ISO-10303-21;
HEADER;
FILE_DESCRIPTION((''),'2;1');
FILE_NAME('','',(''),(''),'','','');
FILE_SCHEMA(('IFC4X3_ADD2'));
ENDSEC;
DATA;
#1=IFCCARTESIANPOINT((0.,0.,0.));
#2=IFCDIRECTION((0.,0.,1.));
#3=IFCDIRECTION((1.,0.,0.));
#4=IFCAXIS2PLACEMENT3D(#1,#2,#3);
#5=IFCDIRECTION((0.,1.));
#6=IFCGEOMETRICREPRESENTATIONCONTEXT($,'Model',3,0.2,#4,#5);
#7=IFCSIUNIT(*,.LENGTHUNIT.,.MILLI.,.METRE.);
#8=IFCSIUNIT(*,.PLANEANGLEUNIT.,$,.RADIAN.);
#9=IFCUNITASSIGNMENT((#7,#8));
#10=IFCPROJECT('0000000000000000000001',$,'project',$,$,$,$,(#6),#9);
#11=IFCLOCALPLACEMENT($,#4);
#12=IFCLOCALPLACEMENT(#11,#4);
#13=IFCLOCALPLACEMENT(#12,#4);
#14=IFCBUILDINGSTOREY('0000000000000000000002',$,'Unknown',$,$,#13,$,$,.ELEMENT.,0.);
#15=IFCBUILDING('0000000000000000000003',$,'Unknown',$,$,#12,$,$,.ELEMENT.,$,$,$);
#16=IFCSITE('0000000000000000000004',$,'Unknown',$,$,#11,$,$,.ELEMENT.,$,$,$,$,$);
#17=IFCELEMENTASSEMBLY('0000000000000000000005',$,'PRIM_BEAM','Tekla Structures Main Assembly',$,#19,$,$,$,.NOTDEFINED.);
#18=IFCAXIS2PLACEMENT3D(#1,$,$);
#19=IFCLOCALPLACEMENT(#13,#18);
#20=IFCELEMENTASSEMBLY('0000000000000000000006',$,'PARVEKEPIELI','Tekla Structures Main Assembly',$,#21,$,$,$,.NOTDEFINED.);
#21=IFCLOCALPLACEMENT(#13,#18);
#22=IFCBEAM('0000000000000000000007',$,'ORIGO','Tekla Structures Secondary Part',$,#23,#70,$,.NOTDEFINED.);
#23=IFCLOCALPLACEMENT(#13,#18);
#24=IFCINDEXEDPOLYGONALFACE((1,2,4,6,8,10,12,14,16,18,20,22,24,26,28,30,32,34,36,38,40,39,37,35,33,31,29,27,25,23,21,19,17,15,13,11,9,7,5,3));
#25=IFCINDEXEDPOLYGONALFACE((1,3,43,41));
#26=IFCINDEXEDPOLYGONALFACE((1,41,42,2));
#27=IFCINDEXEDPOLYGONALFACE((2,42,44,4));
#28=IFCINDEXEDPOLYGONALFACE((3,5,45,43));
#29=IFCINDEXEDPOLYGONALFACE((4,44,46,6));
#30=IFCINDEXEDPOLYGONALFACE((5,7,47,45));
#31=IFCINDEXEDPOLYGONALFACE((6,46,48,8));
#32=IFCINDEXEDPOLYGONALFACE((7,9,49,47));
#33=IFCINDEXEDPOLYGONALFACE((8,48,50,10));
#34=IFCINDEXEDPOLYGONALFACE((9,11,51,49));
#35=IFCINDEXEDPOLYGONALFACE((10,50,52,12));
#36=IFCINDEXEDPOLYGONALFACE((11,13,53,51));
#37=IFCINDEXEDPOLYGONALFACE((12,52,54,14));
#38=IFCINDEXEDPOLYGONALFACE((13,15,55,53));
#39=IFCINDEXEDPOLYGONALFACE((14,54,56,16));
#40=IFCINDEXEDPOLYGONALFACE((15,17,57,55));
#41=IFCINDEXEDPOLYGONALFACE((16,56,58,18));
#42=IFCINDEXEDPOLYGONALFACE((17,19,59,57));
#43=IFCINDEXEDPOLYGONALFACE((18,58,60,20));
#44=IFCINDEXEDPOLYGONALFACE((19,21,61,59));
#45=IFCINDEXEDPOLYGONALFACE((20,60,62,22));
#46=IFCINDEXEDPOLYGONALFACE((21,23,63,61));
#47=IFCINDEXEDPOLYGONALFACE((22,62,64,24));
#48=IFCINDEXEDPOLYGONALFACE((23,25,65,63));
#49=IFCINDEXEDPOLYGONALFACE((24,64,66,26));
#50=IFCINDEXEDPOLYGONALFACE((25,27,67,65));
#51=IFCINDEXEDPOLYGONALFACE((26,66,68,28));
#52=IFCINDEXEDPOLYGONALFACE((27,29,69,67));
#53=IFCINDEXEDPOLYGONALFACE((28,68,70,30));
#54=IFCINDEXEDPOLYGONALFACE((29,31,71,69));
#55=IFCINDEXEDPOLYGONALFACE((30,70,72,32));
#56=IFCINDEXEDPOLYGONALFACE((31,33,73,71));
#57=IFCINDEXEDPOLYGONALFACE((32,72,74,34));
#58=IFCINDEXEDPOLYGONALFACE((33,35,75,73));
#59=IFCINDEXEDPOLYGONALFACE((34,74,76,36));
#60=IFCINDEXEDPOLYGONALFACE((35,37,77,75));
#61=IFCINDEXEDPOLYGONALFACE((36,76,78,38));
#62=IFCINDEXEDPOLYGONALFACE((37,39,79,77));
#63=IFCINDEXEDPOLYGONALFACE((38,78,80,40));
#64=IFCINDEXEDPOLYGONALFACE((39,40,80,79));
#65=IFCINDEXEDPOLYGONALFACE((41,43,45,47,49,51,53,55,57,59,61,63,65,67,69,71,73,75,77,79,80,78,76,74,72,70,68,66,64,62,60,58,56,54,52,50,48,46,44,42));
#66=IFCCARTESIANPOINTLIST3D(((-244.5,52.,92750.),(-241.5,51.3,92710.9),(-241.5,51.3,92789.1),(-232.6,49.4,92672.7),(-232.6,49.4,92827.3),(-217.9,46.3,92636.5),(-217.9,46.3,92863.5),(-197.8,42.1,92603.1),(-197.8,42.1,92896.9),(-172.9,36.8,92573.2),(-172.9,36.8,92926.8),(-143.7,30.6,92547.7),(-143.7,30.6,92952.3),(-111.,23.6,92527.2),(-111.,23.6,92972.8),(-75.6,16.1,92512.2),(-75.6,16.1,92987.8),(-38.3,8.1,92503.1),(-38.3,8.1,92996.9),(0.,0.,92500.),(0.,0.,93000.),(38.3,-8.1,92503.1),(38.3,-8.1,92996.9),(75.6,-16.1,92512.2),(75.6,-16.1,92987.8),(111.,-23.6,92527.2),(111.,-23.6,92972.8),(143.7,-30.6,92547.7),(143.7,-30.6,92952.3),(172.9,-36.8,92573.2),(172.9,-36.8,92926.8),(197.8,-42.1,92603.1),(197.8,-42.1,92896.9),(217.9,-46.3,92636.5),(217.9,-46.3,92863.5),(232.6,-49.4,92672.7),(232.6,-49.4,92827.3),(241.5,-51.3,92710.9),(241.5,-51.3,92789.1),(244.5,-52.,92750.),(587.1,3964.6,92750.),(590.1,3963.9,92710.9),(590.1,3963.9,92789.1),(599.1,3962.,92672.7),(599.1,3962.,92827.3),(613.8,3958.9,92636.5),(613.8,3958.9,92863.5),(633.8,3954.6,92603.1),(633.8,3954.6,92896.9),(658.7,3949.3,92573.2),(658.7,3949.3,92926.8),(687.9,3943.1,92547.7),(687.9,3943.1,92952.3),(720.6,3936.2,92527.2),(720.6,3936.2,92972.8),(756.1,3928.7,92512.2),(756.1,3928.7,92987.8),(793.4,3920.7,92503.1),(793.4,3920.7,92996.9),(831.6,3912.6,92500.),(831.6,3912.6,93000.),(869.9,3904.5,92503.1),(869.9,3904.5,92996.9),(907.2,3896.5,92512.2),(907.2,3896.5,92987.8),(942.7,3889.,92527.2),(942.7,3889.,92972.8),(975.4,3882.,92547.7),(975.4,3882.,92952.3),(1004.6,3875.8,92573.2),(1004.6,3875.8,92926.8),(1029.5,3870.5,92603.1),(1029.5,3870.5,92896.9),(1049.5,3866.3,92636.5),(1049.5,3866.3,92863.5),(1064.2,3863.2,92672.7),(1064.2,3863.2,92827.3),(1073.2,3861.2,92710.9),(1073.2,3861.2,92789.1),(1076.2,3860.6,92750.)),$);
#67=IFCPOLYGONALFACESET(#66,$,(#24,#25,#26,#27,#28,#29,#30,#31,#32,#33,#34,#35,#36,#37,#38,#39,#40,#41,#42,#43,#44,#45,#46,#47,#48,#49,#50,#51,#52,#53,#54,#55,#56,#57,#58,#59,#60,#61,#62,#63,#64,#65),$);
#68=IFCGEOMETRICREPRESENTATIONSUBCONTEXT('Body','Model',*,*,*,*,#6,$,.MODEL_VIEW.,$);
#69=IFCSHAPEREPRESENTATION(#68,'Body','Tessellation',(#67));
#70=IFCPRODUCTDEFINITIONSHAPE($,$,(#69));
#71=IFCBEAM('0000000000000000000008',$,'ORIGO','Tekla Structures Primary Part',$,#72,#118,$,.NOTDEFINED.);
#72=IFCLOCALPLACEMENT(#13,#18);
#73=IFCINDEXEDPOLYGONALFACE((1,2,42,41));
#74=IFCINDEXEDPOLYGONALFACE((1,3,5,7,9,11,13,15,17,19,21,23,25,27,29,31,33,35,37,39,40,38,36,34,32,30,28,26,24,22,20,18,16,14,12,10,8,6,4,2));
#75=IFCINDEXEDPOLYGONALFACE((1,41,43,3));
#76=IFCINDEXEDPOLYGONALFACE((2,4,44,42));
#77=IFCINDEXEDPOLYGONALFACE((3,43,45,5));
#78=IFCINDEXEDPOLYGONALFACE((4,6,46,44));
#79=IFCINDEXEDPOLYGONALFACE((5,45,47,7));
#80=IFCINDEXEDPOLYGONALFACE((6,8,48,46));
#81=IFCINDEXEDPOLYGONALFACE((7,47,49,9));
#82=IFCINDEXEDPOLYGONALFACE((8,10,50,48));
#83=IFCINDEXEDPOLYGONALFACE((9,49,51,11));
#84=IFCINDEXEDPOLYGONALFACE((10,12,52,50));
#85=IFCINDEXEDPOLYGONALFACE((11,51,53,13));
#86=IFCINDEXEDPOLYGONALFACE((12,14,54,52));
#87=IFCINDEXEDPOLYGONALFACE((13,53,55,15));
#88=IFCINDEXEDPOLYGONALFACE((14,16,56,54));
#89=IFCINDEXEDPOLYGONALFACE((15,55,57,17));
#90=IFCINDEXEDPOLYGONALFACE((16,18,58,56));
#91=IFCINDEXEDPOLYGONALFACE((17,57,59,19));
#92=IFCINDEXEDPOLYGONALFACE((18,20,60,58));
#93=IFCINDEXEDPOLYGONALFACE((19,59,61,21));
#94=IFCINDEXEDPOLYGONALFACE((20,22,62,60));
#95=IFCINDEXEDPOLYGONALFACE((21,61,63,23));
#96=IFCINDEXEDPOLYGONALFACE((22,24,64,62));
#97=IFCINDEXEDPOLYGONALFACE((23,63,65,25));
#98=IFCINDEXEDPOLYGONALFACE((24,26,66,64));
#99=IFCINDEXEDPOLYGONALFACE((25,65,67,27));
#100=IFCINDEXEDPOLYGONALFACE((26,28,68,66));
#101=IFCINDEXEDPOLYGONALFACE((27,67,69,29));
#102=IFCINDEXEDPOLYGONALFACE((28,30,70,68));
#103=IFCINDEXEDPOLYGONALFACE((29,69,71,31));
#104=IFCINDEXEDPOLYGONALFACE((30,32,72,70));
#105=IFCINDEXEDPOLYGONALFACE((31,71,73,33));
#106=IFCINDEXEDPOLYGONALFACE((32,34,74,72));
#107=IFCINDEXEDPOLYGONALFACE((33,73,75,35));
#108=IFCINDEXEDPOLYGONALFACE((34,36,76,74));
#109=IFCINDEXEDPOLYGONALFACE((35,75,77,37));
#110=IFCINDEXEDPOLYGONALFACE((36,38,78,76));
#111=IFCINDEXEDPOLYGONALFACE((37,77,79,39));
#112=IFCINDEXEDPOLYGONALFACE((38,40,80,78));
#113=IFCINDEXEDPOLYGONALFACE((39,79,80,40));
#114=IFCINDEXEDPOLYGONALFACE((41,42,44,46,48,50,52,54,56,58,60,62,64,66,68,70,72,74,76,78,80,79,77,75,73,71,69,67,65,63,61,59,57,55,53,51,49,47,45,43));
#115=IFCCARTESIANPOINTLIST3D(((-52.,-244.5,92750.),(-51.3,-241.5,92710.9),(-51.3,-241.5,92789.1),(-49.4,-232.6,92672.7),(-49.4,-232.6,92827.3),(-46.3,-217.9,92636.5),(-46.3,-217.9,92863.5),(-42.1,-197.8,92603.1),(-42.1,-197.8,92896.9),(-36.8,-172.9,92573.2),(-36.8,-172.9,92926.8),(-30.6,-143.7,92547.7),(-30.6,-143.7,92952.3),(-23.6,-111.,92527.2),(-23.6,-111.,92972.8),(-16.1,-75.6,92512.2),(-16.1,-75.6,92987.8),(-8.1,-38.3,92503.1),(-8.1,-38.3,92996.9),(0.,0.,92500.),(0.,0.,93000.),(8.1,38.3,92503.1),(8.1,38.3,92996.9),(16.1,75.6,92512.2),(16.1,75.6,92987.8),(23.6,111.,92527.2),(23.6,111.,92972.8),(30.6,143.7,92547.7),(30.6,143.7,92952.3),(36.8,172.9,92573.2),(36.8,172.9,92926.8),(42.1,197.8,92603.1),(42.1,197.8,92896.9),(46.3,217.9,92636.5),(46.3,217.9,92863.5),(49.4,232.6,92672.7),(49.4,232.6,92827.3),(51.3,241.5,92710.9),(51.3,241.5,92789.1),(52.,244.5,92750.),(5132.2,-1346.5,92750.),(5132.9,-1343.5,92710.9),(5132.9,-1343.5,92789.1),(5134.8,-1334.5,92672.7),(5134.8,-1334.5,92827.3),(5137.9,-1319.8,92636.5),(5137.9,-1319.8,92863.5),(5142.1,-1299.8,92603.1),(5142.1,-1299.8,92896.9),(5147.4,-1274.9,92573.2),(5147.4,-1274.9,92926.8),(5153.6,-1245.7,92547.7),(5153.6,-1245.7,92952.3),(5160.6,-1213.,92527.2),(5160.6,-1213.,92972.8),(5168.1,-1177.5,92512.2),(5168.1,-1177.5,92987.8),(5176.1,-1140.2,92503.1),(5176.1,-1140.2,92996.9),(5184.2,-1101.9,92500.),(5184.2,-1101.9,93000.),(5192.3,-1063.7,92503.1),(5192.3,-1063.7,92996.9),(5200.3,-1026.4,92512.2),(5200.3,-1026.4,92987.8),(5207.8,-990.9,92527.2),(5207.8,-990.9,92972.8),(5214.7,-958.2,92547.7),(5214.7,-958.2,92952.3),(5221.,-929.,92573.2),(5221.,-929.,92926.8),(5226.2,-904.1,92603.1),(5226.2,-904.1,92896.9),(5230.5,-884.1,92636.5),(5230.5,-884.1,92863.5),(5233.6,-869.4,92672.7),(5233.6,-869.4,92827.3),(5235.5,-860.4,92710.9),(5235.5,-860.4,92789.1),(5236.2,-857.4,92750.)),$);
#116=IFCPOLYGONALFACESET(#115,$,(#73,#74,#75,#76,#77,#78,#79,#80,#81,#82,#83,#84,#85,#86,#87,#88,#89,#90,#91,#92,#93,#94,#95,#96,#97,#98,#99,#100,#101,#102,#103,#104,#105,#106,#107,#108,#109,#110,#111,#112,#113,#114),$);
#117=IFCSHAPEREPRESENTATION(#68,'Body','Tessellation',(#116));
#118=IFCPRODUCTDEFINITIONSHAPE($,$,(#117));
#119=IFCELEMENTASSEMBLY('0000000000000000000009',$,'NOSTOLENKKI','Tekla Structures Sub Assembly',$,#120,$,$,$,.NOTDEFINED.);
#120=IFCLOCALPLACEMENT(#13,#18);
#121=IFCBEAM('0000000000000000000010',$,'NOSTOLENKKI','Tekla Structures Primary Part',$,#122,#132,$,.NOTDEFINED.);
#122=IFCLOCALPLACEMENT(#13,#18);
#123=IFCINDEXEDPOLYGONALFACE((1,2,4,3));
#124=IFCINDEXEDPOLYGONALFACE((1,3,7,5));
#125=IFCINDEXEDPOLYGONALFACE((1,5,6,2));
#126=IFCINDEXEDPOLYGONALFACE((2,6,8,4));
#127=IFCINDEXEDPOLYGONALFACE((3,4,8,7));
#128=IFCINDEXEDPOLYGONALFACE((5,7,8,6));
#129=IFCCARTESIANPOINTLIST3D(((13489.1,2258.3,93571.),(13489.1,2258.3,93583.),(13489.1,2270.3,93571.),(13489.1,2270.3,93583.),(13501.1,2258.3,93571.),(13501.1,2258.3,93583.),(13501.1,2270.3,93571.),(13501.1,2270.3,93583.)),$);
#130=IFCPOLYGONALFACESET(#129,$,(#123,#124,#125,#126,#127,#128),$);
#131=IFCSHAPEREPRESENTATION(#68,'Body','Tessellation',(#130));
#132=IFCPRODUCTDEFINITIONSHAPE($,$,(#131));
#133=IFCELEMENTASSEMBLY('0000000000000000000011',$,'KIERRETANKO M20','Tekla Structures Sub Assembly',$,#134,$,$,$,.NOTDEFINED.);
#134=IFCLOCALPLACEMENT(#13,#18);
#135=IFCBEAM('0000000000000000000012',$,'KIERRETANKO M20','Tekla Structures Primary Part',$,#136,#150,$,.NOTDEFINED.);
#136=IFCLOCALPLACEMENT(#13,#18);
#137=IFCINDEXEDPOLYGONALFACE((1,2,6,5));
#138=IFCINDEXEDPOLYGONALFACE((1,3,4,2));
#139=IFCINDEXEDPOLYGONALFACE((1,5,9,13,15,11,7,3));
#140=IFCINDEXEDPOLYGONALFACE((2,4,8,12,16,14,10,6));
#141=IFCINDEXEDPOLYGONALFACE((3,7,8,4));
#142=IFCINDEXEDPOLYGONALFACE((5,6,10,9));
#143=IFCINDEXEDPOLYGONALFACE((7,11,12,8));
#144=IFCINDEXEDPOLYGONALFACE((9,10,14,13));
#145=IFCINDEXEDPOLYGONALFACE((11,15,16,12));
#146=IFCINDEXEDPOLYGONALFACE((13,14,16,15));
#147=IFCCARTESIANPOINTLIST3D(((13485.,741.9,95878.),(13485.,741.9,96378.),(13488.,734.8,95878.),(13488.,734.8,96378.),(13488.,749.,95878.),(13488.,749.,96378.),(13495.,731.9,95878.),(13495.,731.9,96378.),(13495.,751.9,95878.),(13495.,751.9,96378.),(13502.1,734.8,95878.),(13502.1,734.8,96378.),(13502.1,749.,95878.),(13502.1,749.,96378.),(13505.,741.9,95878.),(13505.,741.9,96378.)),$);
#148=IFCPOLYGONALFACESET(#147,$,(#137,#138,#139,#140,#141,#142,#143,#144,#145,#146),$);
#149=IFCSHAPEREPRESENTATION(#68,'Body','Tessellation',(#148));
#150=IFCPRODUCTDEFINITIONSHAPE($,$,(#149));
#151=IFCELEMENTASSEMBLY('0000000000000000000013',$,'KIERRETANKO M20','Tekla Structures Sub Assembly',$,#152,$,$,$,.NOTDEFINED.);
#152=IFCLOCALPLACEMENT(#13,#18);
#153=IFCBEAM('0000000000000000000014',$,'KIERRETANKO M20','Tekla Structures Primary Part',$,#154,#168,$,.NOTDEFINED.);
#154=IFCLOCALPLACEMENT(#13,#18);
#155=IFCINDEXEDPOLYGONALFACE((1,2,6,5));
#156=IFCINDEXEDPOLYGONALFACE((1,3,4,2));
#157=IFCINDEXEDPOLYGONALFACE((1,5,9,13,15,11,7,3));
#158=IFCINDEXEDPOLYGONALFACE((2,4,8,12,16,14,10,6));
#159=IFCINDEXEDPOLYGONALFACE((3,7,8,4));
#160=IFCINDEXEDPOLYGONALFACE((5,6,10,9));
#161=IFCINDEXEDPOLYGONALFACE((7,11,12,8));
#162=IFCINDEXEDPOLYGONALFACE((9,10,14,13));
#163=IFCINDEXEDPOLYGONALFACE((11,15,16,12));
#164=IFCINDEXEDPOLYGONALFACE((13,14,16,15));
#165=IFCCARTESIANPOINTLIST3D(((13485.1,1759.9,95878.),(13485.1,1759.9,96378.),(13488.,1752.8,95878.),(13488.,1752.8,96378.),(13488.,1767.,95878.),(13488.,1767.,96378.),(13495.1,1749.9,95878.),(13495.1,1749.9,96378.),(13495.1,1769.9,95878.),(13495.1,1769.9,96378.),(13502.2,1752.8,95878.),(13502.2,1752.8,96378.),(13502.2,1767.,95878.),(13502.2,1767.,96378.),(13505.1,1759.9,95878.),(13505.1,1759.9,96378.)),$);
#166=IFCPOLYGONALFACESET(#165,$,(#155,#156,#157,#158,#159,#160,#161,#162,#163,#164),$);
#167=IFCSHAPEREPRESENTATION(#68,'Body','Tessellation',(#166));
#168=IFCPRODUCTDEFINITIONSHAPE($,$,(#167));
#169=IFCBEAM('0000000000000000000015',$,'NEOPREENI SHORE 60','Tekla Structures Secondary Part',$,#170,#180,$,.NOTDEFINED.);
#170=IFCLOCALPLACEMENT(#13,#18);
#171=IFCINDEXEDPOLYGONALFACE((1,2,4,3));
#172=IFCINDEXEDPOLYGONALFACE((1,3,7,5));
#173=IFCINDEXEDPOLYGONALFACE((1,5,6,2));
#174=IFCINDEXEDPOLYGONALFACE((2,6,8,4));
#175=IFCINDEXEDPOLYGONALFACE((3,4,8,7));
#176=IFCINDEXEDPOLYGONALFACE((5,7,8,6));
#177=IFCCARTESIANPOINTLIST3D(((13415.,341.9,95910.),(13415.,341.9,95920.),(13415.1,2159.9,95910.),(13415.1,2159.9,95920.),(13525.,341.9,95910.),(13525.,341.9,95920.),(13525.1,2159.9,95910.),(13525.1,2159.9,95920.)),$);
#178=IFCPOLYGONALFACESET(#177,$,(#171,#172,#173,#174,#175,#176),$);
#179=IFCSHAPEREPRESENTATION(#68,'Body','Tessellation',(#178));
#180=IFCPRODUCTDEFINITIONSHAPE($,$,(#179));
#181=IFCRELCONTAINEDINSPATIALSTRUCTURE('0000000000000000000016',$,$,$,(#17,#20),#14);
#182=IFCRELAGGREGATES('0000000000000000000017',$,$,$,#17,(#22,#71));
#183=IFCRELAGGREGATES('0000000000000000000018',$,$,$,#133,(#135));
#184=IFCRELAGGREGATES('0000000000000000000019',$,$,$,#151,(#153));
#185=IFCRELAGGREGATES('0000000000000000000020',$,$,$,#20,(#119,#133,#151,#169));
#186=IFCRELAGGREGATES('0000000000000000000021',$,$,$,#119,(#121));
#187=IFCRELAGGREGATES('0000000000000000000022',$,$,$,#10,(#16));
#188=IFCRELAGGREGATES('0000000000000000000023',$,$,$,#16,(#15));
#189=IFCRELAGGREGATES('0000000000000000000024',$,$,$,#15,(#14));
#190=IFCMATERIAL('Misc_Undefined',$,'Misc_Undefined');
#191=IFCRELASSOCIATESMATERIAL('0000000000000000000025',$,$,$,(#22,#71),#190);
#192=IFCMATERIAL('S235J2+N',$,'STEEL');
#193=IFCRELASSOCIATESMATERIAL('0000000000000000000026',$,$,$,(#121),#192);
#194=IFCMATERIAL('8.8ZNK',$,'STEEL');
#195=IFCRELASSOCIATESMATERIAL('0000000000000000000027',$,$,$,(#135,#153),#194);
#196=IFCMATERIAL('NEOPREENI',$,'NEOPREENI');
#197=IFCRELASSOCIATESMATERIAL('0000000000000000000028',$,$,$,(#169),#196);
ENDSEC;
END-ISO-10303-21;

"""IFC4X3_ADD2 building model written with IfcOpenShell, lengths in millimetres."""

from ifc_helpers import new_model, si_unit, direction, frame, origin_with_axes, place, context, subcontext, project, spatial, line, indexed_curve, outline, extrude, material, element, aggregate, save


model = new_model("IFC4X3_ADD2")

# Units and contexts
model_context = context("Model", 3, precision=0.2, world=origin_with_axes(), true_north=direction((0.0, 1.0)))
body_context = subcontext(model_context, "Body", "Model", "MODEL_VIEW")
ifc_project = project(units=[si_unit("LENGTHUNIT", "METRE", prefix="MILLI"), si_unit("PLANEANGLEUNIT", "RADIAN")], contexts=[model_context])

# Site, building, storey
site_placement = place(None, origin_with_axes())
site = spatial("IfcSite", under=ifc_project, at=site_placement, Name="Unknown", CompositionType="ELEMENT")
building_placement = place(site_placement, origin_with_axes())
building = spatial("IfcBuilding", under=site, at=building_placement, Name="Unknown", CompositionType="ELEMENT")
storey_placement = place(building_placement, origin_with_axes())
storey = spatial("IfcBuildingStorey", under=building, at=storey_placement, Name="Unknown", CompositionType="ELEMENT", Elevation=0.0)

# Element assembly
assembly_1_placement = place(storey_placement, frame((0.0, 0.0, 92750.0), z_axis=(-0.207912, -0.978147, 0.0), x_axis=(0.978147, -0.207912, 0.0)))
assembly_1 = element("IfcElementAssembly", 1, at=assembly_1_placement, inside=storey, Name="PRIM_BEAM", Description="Tekla Structures Main Assembly", PredefinedType="NOTDEFINED")
ifc_material_1 = material(Name="Misc_Undefined", Category="Misc_Undefined")

# Element assembly
assembly_2_placement = place(storey_placement, frame((13495.0, 341.9, 94460.0), z_axis=(1.0, -0.000056, 0.0), x_axis=(0.000056, 1.0, 0.0)))
assembly_2 = element("IfcElementAssembly", 2, at=assembly_2_placement, inside=storey, Name="PARVEKEPIELI", Description="Tekla Structures Main Assembly", PredefinedType="NOTDEFINED")

# Beams
beam_1_placement = place(assembly_1_placement, frame((0.0, 0.0, 0.0), z_axis=(1.0, 0.0, 0.0), x_axis=(0.0, 0.0, -1.0)))
beam_1 = element("IfcBeam", 3, at=beam_1_placement, material=ifc_material_1, Name="ORIGO", Description="Tekla Structures Secondary Part", PredefinedType="NOTDEFINED", context=body_context, shape_type="SolidModel", body=[
    extrude(outline(indexed_curve([(250.0, 0.0), (246.9, 39.1), (237.8, 77.3), (222.8, 113.5), (202.3, 146.9), (176.8, 176.8), (146.9, 202.3), (113.5, 222.8), (77.3, 237.8), (39.1, 246.9), (0.0, 250.0), (-39.1, 246.9), (-77.3, 237.8), (-113.5, 222.8), (-146.9, 202.3), (-176.8, 176.8), (-202.3, 146.9), (-222.8, 113.5), (-237.8, 77.3), (-246.9, 39.1), (-250.0, 0.0), (-246.9, -39.1), (-237.8, -77.3), (-222.8, -113.5), (-202.3, -146.9), (-176.8, -176.8), (-146.9, -202.3), (-113.5, -222.8), (-77.3, -237.8), (-39.1, -246.9), (0.0, -250.0), (39.1, -246.9), (77.3, -237.8), (113.5, -222.8), (146.9, -202.3), (176.8, -176.8), (202.3, -146.9), (222.8, -113.5), (237.8, -77.3), (246.9, -39.1)], segments=[line(1, 2, 3, 4, 5, 6, 7, 8, 9, 10, 11, 12, 13, 14, 15, 16, 17, 18, 19, 20, 21, 22, 23, 24, 25, 26, 27, 28, 29, 30, 31, 32, 33, 34, 35, 36, 37, 38, 39, 40, 1)])), frame((0.0, 0.0, 0.0), z_axis=(-1.0, 0.0, 0.0), x_axis=(0.0, 0.0, 1.0)), (0.0, 0.0, -1.0), 4000.0),
])
beam_2_placement = place(assembly_1_placement, origin_with_axes())
beam_2 = element("IfcBeam", 4, at=beam_2_placement, material=ifc_material_1, Name="ORIGO", Description="Tekla Structures Primary Part", PredefinedType="NOTDEFINED", context=body_context, shape_type="SolidModel", body=[
    extrude(outline(indexed_curve([(250.0, 0.0), (246.9, 39.1), (237.8, 77.3), (222.8, 113.5), (202.3, 146.9), (176.8, 176.8), (146.9, 202.3), (113.5, 222.8), (77.3, 237.8), (39.1, 246.9), (0.0, 250.0), (-39.1, 246.9), (-77.3, 237.8), (-113.5, 222.8), (-146.9, 202.3), (-176.8, 176.8), (-202.3, 146.9), (-222.8, 113.5), (-237.8, 77.3), (-246.9, 39.1), (-250.0, 0.0), (-246.9, -39.1), (-237.8, -77.3), (-222.8, -113.5), (-202.3, -146.9), (-176.8, -176.8), (-146.9, -202.3), (-113.5, -222.8), (-77.3, -237.8), (-39.1, -246.9), (0.0, -250.0), (39.1, -246.9), (77.3, -237.8), (113.5, -222.8), (146.9, -202.3), (176.8, -176.8), (202.3, -146.9), (222.8, -113.5), (237.8, -77.3), (246.9, -39.1)], segments=[line(1, 2, 3, 4, 5, 6, 7, 8, 9, 10, 11, 12, 13, 14, 15, 16, 17, 18, 19, 20, 21, 22, 23, 24, 25, 26, 27, 28, 29, 30, 31, 32, 33, 34, 35, 36, 37, 38, 39, 40, 1)])), frame((0.0, 0.0, 0.0), z_axis=(-1.0, 0.0, 0.0), x_axis=(0.0, 0.0, 1.0)), (0.0, 0.0, -1.0), 5300.0),
])
aggregate(assembly_1, [beam_1, beam_2])

# Element assemblies, beams
assembly_3_placement = place(assembly_2_placement, frame((1922.4, -877.0, 0.0), z_axis=(0.0, 0.0, 1.0), x_axis=(0.0, -1.0, 0.0)))
assembly_3 = element("IfcElementAssembly", 5, at=assembly_3_placement, Name="NOSTOLENKKI", Description="Tekla Structures Sub Assembly", PredefinedType="NOTDEFINED")
ifc_material_2 = material(Name="S235J2+N", Category="STEEL")
beam_3_placement = place(assembly_3_placement, origin_with_axes())
beam_3 = element("IfcBeam", 6, at=beam_3_placement, material=ifc_material_2, Name="NOSTOLENKKI", Description="Tekla Structures Primary Part", PredefinedType="NOTDEFINED", context=body_context, shape_type="SolidModel", body=[
    extrude(outline(indexed_curve([(-6.0, -6.0), (6.0, -6.0), (6.0, 6.0), (-6.0, 6.0)], segments=[line(1, 2, 3, 4, 1)])), frame((0.0, 0.0, 0.0), z_axis=(-1.0, 0.0, 0.0), x_axis=(0.0, 0.0, 1.0)), (0.0, 0.0, -1.0), 12.0),
])
assembly_4_placement = place(assembly_2_placement, frame((400.0, 1918.0, 0.0), z_axis=(1.0, 0.0, -0.000004), x_axis=(0.0, -1.0, 0.0)))
assembly_4 = element("IfcElementAssembly", 7, at=assembly_4_placement, Name="KIERRETANKO M20", Description="Tekla Structures Sub Assembly", PredefinedType="NOTDEFINED")
ifc_material_3 = material(Name="8.8ZNK", Category="STEEL")
beam_4_placement = place(assembly_4_placement, origin_with_axes())
beam_4 = element("IfcBeam", 8, at=beam_4_placement, material=ifc_material_3, Name="KIERRETANKO M20", Description="Tekla Structures Primary Part", PredefinedType="NOTDEFINED", context=body_context, shape_type="SolidModel", body=[
    extrude(outline(indexed_curve([(10.0, 0.0), (7.1, 7.1), (0.0, 10.0), (-7.1, 7.1), (-10.0, 0.0), (-7.1, -7.1), (0.0, -10.0), (7.1, -7.1)], segments=[line(1, 2, 3, 4, 5, 6, 7, 8, 1)])), frame((0.0, 0.0, 0.0), z_axis=(-1.0, 0.0, 0.0), x_axis=(0.0, 0.0, 1.0)), (0.0, 0.0, -1.0), 500.0),
])
aggregate(assembly_4, [beam_4])
assembly_5_placement = place(assembly_2_placement, frame((1418.0, 1918.0, 0.0), z_axis=(1.0, 0.0, -0.000004), x_axis=(0.0, -1.0, 0.0)))
assembly_5 = element("IfcElementAssembly", 9, at=assembly_5_placement, Name="KIERRETANKO M20", Description="Tekla Structures Sub Assembly", PredefinedType="NOTDEFINED")
beam_5_placement = place(assembly_5_placement, origin_with_axes())
beam_5 = element("IfcBeam", 10, at=beam_5_placement, material=ifc_material_3, Name="KIERRETANKO M20", Description="Tekla Structures Primary Part", PredefinedType="NOTDEFINED", context=body_context, shape_type="SolidModel", body=[
    extrude(outline(indexed_curve([(10.0, 0.0), (7.1, 7.1), (0.0, 10.0), (-7.1, 7.1), (-10.0, 0.0), (-7.1, -7.1), (0.0, -10.0), (7.1, -7.1)], segments=[line(1, 2, 3, 4, 5, 6, 7, 8, 1)])), frame((0.0, 0.0, 0.0), z_axis=(-1.0, 0.0, 0.0), x_axis=(0.0, 0.0, 1.0)), (0.0, 0.0, -1.0), 500.0),
])
aggregate(assembly_5, [beam_5])

# Beam
ifc_material_4 = material(Name="NEOPREENI", Category="NEOPREENI")
beam_6_placement = place(assembly_2_placement, frame((0.0, 1455.0, -25.0), z_axis=(0.0, 0.0, 1.0), x_axis=(1.0, 0.0, 0.0)))
beam_6 = element("IfcBeam", 11, at=beam_6_placement, material=ifc_material_4, Name="NEOPREENI SHORE 60", Description="Tekla Structures Secondary Part", PredefinedType="NOTDEFINED", context=body_context, shape_type="SolidModel", body=[
    extrude(outline(indexed_curve([(-55.0, -5.0), (55.0, -5.0), (55.0, 5.0), (-55.0, 5.0)], segments=[line(1, 2, 3, 4, 1)])), frame((0.0, 0.0, 0.0), z_axis=(-1.0, 0.0, 0.0), x_axis=(0.0, 0.0, 1.0)), (0.0, 0.0, -1.0), 1818.0),
])
aggregate(assembly_2, [assembly_3, assembly_4, assembly_5, beam_6])

aggregate(assembly_3, [beam_3])

save(model, "model.ifc")
